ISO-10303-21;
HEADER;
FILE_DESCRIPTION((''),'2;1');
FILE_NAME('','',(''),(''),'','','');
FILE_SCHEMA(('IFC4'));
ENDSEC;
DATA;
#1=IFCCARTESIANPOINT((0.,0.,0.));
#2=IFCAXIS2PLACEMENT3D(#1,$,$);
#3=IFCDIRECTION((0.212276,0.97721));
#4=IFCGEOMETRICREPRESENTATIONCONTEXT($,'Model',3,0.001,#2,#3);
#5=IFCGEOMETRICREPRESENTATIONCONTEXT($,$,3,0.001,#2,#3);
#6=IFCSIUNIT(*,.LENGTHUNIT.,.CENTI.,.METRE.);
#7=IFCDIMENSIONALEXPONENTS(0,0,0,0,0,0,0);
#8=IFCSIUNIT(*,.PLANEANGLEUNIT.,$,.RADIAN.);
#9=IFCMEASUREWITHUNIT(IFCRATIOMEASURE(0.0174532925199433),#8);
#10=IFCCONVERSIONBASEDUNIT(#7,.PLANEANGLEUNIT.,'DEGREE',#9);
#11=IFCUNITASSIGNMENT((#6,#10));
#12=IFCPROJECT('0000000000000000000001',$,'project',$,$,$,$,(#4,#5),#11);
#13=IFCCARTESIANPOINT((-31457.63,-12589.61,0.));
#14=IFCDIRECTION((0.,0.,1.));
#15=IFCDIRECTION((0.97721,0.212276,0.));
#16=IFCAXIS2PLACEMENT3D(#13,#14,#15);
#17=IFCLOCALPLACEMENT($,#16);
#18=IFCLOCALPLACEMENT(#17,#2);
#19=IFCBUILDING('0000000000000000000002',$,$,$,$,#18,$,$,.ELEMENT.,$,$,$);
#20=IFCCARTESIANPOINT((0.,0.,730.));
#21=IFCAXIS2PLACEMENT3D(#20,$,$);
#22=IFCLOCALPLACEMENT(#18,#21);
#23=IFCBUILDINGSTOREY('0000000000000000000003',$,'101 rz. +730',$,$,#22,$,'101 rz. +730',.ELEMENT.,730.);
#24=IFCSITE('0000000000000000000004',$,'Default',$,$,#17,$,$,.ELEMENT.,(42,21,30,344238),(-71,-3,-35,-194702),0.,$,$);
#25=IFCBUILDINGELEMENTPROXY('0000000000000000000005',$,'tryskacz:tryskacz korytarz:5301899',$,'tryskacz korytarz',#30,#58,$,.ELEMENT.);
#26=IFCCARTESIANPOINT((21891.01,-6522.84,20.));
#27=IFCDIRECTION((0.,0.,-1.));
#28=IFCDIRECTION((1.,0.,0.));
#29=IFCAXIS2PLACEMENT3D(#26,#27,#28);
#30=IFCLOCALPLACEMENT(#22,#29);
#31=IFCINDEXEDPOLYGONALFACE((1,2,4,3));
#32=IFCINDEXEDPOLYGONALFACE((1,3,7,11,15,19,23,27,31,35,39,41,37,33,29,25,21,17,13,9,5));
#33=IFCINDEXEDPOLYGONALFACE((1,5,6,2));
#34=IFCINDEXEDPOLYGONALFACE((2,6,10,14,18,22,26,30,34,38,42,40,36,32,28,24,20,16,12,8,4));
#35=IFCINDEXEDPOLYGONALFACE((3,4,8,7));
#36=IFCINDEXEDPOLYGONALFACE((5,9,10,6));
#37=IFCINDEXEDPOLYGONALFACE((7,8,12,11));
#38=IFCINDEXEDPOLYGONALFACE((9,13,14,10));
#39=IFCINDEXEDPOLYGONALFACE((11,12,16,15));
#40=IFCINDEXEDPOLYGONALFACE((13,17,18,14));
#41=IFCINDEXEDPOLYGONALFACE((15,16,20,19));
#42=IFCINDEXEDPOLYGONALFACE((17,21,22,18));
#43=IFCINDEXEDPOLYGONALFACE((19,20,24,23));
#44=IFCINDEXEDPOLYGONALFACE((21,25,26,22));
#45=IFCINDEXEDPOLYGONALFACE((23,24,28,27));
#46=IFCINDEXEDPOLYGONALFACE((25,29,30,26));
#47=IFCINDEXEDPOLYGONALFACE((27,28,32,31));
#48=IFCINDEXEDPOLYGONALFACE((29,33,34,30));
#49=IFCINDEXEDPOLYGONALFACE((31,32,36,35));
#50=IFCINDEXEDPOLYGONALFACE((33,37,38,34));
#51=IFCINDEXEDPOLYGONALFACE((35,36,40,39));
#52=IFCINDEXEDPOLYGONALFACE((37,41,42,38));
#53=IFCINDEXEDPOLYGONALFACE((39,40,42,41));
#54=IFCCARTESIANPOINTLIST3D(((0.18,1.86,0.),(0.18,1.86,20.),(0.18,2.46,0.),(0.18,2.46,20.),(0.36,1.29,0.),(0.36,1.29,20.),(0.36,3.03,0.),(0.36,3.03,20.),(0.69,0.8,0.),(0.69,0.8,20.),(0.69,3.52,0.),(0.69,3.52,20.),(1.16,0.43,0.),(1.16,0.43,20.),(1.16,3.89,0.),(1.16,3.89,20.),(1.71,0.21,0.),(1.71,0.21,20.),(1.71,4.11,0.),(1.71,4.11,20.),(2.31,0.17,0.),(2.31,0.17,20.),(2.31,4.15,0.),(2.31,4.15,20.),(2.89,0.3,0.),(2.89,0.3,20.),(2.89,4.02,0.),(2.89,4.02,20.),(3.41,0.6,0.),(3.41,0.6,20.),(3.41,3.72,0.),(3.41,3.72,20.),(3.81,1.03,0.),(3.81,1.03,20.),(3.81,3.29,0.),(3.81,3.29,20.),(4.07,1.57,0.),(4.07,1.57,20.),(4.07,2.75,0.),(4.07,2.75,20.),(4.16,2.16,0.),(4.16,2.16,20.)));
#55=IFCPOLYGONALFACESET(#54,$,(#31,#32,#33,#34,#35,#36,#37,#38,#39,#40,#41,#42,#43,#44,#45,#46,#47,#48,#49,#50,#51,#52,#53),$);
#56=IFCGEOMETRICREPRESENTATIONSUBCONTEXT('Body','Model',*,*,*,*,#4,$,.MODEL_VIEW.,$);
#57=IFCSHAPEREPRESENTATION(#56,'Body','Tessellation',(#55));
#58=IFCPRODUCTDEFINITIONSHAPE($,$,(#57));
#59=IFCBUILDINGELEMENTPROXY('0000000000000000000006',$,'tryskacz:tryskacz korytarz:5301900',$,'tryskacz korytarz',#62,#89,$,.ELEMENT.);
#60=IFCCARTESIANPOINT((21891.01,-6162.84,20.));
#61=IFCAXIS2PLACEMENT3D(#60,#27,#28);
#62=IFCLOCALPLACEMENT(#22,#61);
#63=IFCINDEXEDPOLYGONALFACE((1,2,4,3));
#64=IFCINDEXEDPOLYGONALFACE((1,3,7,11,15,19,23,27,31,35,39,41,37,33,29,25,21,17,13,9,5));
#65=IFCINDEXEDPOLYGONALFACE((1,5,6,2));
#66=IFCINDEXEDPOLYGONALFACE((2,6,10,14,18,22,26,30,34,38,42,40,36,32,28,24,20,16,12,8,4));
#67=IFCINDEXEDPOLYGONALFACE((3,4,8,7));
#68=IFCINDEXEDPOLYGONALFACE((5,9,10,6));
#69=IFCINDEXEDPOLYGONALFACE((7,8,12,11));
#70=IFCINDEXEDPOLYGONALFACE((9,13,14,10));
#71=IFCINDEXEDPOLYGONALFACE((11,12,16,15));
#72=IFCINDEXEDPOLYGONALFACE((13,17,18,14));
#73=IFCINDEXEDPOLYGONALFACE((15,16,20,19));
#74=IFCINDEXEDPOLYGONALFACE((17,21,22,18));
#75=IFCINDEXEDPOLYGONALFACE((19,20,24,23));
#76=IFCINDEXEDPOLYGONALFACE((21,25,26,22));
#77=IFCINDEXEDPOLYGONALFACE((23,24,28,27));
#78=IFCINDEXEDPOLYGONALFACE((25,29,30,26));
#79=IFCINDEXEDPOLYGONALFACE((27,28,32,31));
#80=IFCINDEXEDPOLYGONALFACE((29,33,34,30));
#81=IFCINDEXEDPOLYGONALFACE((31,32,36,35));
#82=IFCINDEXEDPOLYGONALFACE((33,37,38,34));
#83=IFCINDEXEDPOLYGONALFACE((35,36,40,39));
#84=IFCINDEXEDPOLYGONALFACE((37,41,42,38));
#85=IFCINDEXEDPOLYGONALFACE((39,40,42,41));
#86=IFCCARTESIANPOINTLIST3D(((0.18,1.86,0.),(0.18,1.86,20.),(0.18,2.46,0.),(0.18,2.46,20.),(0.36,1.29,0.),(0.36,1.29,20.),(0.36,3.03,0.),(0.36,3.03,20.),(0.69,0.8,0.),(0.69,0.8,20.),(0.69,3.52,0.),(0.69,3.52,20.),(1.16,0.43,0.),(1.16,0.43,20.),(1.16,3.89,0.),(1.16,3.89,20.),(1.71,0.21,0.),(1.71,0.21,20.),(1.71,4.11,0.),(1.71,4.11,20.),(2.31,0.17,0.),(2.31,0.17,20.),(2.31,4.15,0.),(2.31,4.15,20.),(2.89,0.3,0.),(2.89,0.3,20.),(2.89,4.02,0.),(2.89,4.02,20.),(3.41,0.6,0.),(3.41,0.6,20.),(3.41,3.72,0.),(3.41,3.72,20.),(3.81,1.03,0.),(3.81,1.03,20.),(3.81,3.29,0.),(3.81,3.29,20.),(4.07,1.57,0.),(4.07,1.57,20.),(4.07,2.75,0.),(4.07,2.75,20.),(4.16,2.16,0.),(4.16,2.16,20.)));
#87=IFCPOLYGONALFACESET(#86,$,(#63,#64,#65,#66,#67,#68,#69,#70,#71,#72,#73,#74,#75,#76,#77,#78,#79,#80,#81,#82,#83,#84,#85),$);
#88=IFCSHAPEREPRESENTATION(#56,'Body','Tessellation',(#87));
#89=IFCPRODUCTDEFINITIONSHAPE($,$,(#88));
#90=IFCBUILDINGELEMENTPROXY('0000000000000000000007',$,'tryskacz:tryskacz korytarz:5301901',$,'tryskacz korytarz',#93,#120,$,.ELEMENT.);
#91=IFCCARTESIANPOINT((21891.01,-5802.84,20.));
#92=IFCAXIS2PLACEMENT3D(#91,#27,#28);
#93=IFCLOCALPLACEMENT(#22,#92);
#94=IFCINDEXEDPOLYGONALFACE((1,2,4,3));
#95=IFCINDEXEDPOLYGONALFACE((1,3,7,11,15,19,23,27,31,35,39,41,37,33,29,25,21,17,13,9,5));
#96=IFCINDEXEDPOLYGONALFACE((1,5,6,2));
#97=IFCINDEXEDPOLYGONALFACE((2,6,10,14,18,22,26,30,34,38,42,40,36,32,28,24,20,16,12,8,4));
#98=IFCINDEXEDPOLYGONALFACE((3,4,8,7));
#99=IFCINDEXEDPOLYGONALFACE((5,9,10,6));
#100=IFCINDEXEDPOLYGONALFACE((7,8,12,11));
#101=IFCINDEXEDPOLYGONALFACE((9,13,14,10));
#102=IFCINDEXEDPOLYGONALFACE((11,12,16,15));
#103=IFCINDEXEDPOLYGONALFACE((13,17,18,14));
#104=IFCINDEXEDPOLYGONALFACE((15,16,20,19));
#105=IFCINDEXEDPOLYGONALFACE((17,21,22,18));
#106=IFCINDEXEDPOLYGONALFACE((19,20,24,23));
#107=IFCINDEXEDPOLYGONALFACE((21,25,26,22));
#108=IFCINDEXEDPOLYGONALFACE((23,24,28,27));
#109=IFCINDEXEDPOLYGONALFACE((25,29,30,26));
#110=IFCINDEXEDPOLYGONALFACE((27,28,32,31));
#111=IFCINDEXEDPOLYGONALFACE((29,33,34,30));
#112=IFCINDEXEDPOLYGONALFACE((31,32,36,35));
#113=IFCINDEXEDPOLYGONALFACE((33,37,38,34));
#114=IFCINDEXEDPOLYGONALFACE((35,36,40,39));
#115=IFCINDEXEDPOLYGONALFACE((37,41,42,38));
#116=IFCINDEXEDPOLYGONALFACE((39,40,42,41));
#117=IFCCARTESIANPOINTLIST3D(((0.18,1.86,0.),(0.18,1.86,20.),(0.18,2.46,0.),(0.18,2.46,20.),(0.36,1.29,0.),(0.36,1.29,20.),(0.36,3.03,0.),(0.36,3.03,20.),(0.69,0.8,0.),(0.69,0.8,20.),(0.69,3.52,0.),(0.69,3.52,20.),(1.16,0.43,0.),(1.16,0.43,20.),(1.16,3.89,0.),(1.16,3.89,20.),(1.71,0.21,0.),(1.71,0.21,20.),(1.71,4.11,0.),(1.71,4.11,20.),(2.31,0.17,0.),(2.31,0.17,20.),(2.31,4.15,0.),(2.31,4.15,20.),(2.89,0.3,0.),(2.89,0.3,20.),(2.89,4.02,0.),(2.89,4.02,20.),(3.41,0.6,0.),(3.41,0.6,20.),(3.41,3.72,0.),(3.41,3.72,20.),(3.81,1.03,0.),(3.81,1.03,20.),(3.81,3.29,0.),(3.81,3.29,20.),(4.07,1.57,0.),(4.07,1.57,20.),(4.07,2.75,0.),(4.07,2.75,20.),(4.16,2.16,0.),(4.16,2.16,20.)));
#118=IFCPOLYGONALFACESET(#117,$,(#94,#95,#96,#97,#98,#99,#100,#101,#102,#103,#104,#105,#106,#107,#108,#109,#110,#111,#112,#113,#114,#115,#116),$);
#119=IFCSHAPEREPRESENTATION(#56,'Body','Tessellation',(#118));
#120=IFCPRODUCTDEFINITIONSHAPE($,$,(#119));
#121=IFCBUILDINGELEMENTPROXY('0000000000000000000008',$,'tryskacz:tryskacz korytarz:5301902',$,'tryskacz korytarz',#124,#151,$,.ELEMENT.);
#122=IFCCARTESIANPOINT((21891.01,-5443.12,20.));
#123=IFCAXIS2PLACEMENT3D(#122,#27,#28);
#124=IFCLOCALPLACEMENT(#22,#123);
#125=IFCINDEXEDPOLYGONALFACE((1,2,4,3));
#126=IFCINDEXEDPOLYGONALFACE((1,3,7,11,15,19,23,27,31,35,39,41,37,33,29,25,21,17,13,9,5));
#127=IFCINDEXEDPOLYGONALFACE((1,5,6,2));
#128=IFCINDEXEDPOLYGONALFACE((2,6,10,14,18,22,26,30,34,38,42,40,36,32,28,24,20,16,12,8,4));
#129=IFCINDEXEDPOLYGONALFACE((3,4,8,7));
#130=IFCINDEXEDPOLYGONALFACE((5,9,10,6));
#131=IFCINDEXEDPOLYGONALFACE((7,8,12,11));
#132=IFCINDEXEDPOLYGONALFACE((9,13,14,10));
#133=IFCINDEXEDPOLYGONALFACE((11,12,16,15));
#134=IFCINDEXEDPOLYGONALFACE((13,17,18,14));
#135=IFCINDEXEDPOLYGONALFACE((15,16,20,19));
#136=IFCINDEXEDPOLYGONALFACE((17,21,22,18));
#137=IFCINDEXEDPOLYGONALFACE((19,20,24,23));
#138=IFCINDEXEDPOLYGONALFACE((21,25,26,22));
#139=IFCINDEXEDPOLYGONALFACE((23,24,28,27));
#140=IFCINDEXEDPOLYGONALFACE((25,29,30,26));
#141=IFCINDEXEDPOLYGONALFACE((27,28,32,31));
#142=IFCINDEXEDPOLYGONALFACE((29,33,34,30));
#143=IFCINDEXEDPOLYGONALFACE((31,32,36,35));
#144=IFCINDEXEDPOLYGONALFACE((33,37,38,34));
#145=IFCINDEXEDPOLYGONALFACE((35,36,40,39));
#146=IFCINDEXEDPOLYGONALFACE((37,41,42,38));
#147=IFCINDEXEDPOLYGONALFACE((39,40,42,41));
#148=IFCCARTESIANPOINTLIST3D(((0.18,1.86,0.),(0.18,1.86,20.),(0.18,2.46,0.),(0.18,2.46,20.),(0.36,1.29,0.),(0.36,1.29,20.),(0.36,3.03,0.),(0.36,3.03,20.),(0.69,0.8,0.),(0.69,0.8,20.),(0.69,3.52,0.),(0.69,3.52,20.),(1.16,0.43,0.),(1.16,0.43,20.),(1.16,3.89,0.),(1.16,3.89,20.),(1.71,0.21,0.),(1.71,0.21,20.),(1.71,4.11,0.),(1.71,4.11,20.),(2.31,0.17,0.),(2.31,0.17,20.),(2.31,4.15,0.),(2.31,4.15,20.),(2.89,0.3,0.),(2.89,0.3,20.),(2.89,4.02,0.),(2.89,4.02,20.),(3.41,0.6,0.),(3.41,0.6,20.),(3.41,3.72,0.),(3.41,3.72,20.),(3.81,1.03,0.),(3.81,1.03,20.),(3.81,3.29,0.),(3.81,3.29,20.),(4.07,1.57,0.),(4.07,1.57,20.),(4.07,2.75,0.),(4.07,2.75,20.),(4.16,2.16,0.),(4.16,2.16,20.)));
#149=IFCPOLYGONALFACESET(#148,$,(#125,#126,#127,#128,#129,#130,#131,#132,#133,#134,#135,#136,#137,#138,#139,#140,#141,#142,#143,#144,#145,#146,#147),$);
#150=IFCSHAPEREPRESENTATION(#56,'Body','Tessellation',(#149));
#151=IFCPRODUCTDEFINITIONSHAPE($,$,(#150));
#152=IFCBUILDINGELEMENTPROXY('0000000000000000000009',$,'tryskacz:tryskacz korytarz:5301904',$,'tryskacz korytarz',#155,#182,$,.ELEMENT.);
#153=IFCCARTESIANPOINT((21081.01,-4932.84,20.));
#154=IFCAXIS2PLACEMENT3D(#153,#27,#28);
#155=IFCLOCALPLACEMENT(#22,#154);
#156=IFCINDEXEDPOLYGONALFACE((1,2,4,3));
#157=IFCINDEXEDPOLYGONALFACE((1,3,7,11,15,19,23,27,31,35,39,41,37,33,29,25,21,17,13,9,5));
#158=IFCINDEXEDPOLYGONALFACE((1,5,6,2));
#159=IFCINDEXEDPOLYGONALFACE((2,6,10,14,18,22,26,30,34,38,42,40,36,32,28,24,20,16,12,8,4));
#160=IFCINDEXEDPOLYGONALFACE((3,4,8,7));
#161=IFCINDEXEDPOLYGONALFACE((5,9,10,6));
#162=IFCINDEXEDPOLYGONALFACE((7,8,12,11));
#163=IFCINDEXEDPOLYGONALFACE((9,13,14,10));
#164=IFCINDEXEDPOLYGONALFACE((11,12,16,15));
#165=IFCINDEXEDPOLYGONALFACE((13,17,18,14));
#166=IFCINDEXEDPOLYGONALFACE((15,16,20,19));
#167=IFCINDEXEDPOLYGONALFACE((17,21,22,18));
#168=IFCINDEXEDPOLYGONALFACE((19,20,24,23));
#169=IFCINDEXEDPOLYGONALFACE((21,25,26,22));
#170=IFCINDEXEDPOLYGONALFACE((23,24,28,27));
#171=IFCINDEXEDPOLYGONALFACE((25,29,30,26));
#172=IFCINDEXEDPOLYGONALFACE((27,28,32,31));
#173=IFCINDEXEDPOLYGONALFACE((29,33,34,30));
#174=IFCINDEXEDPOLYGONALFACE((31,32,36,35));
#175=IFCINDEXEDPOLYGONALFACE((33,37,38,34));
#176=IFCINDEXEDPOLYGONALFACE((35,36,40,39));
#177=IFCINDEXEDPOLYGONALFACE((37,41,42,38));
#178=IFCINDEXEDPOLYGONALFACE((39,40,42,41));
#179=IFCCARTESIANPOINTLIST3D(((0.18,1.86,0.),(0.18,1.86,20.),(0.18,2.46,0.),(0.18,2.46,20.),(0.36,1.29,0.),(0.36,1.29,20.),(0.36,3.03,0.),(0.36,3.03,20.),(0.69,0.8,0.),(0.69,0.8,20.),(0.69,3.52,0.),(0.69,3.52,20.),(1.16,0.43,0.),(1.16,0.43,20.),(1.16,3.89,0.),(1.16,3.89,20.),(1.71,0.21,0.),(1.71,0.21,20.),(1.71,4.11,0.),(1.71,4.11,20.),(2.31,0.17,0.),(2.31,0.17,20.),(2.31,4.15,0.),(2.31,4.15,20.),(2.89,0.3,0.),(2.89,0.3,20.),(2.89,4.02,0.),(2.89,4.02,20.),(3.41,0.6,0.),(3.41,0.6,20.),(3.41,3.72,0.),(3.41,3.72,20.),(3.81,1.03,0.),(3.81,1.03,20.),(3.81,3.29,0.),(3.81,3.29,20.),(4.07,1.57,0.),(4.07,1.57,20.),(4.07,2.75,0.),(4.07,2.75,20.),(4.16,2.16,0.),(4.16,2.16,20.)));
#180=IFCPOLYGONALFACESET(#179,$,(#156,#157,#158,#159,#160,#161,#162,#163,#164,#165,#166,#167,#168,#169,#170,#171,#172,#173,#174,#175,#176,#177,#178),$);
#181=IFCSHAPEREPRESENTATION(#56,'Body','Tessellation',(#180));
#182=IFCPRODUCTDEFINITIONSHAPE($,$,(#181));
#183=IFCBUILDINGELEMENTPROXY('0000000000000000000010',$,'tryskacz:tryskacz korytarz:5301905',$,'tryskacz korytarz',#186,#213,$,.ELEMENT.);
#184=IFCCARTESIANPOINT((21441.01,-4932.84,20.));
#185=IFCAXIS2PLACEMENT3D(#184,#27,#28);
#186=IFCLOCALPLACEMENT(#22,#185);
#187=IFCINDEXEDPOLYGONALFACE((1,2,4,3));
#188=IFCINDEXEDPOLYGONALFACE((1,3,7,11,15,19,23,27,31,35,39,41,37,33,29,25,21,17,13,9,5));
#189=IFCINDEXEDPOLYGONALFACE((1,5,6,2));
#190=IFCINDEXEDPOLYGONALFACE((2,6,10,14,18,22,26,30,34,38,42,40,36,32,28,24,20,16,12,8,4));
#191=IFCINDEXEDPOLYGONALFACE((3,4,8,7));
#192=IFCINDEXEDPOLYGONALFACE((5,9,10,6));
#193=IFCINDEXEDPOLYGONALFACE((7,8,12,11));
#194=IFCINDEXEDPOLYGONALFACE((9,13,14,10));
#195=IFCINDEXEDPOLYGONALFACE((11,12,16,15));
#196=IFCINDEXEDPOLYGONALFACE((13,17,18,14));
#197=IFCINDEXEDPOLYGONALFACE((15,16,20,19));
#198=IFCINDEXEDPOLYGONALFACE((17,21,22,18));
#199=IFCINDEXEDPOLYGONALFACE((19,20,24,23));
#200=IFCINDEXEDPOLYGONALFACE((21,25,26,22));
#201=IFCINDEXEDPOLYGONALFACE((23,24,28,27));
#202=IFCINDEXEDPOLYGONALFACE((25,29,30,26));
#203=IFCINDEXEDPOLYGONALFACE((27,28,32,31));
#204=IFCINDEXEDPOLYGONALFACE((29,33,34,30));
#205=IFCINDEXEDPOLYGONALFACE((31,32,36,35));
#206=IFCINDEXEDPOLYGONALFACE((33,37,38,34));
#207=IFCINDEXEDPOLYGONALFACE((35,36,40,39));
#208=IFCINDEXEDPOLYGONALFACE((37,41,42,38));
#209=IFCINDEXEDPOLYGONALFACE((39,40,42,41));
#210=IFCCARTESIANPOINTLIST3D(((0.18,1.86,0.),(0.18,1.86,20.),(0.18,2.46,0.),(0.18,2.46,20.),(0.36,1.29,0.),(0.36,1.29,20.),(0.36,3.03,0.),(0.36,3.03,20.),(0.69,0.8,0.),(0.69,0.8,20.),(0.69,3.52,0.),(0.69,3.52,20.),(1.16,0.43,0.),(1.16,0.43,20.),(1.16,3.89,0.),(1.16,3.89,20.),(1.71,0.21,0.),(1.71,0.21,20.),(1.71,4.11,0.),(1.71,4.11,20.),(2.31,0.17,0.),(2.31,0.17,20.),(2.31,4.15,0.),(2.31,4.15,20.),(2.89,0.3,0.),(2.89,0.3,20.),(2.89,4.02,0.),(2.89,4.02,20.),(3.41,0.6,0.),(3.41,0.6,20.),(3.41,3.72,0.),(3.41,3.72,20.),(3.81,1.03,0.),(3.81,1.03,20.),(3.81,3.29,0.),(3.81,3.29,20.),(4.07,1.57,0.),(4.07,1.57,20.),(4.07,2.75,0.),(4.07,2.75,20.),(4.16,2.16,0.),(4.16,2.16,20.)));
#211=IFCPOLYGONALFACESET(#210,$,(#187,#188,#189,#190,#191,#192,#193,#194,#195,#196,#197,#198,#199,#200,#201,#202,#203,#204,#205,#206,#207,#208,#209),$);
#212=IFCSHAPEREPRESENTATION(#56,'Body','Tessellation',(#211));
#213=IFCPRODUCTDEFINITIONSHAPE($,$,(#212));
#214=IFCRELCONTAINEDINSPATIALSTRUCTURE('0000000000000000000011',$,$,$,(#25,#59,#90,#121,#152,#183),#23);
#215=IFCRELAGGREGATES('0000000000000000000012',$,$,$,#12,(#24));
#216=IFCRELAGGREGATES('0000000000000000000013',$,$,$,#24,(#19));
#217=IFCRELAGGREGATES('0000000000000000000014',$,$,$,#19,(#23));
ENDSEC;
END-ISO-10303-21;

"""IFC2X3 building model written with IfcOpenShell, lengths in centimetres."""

from ifc_helpers import new_model, entity, si_unit, converted_unit, direction, frame, frame_2d, origin, place, context, subcontext, project, spatial, circle, extrude, source, transform, mapped, element, save


model = new_model("IFC2X3")

# Units and contexts
model_context = context("Model", 3, precision=0.001, world=origin(), true_north=direction((0.212276, 0.97721)))
context_of_model = context(None, 3, precision=0.001, world=origin(), true_north=direction((0.212276, 0.97721)))
body_context = subcontext(model_context, "Body", "Model", "MODEL_VIEW")
ifc_project = project(units=[si_unit("LENGTHUNIT", "METRE", prefix="CENTI"), converted_unit("PLANEANGLEUNIT", "DEGREE", entity("IfcRatioMeasure", 0.0174532925199433), si_unit("PLANEANGLEUNIT", "RADIAN"), dimensions=[0, 0, 0, 0, 0, 0, 0])], contexts=[model_context, context_of_model])

# Site, building, storey
site_placement = place(None, frame((-31457.63, -12589.61, 0.0), z_axis=(0.0, 0.0, 1.0), x_axis=(0.97721, 0.212276, 0.0)))
site = spatial("IfcSite", under=ifc_project, at=site_placement, Name="Default", CompositionType="ELEMENT", RefLatitude=(42, 21, 30, 344238), RefLongitude=(-71, -3, -35, -194702), RefElevation=0.0)
building_placement = place(site_placement, origin())
building = spatial("IfcBuilding", under=site, at=building_placement, CompositionType="ELEMENT")
storey_placement = place(building_placement, frame((0.0, 0.0, 730.0)))
storey = spatial("IfcBuildingStorey", under=building, at=storey_placement, Name="101 rz. +730", LongName="101 rz. +730", CompositionType="ELEMENT", Elevation=730.0)

# Building element proxies
shared_shape_1 = source(origin(), body_context, "Body", "SweptSolid", [
    extrude(circle(Radius=2.0, at=frame_2d((0.0, 0.0), x_axis=(1.0, 0.0))), frame((2.16, 2.16, 0.0)), (0.0, 0.0, 1.0), 20.0),
])
for number, where, z_axis, x_axis, name in (
    (1, (21891.01, -6522.84, 20.0), (0.0, 0.0, -1.0), (1.0, 0.0, 0.0), "tryskacz:tryskacz korytarz:5301899"),
    (2, (21891.01, -6162.84, 20.0), (0.0, 0.0, -1.0), (1.0, 0.0, 0.0), "tryskacz:tryskacz korytarz:5301900"),
    (3, (21891.01, -5802.84, 20.0), (0.0, 0.0, -1.0), (1.0, 0.0, 0.0), "tryskacz:tryskacz korytarz:5301901"),
    (4, (21891.01, -5443.12, 20.0), (0.0, 0.0, -1.0), (1.0, 0.0, 0.0), "tryskacz:tryskacz korytarz:5301902"),
    (5, (21081.01, -4932.84, 20.0), (0.0, 0.0, -1.0), (1.0, 0.0, 0.0), "tryskacz:tryskacz korytarz:5301904"),
    (6, (21441.01, -4932.84, 20.0), (0.0, 0.0, -1.0), (1.0, 0.0, 0.0), "tryskacz:tryskacz korytarz:5301905"),
):
    element("IfcBuildingElementProxy", number, at=place(storey_placement, frame(where, z_axis=z_axis, x_axis=x_axis)), inside=storey, Name=name, ObjectType="tryskacz korytarz", CompositionType="ELEMENT", context=body_context, shape_type="MappedRepresentation", body=[
        mapped(shared_shape_1, transform((0.0, 0.0, 0.0), scale=1.0)),
    ])

save(model, "model.ifc")
